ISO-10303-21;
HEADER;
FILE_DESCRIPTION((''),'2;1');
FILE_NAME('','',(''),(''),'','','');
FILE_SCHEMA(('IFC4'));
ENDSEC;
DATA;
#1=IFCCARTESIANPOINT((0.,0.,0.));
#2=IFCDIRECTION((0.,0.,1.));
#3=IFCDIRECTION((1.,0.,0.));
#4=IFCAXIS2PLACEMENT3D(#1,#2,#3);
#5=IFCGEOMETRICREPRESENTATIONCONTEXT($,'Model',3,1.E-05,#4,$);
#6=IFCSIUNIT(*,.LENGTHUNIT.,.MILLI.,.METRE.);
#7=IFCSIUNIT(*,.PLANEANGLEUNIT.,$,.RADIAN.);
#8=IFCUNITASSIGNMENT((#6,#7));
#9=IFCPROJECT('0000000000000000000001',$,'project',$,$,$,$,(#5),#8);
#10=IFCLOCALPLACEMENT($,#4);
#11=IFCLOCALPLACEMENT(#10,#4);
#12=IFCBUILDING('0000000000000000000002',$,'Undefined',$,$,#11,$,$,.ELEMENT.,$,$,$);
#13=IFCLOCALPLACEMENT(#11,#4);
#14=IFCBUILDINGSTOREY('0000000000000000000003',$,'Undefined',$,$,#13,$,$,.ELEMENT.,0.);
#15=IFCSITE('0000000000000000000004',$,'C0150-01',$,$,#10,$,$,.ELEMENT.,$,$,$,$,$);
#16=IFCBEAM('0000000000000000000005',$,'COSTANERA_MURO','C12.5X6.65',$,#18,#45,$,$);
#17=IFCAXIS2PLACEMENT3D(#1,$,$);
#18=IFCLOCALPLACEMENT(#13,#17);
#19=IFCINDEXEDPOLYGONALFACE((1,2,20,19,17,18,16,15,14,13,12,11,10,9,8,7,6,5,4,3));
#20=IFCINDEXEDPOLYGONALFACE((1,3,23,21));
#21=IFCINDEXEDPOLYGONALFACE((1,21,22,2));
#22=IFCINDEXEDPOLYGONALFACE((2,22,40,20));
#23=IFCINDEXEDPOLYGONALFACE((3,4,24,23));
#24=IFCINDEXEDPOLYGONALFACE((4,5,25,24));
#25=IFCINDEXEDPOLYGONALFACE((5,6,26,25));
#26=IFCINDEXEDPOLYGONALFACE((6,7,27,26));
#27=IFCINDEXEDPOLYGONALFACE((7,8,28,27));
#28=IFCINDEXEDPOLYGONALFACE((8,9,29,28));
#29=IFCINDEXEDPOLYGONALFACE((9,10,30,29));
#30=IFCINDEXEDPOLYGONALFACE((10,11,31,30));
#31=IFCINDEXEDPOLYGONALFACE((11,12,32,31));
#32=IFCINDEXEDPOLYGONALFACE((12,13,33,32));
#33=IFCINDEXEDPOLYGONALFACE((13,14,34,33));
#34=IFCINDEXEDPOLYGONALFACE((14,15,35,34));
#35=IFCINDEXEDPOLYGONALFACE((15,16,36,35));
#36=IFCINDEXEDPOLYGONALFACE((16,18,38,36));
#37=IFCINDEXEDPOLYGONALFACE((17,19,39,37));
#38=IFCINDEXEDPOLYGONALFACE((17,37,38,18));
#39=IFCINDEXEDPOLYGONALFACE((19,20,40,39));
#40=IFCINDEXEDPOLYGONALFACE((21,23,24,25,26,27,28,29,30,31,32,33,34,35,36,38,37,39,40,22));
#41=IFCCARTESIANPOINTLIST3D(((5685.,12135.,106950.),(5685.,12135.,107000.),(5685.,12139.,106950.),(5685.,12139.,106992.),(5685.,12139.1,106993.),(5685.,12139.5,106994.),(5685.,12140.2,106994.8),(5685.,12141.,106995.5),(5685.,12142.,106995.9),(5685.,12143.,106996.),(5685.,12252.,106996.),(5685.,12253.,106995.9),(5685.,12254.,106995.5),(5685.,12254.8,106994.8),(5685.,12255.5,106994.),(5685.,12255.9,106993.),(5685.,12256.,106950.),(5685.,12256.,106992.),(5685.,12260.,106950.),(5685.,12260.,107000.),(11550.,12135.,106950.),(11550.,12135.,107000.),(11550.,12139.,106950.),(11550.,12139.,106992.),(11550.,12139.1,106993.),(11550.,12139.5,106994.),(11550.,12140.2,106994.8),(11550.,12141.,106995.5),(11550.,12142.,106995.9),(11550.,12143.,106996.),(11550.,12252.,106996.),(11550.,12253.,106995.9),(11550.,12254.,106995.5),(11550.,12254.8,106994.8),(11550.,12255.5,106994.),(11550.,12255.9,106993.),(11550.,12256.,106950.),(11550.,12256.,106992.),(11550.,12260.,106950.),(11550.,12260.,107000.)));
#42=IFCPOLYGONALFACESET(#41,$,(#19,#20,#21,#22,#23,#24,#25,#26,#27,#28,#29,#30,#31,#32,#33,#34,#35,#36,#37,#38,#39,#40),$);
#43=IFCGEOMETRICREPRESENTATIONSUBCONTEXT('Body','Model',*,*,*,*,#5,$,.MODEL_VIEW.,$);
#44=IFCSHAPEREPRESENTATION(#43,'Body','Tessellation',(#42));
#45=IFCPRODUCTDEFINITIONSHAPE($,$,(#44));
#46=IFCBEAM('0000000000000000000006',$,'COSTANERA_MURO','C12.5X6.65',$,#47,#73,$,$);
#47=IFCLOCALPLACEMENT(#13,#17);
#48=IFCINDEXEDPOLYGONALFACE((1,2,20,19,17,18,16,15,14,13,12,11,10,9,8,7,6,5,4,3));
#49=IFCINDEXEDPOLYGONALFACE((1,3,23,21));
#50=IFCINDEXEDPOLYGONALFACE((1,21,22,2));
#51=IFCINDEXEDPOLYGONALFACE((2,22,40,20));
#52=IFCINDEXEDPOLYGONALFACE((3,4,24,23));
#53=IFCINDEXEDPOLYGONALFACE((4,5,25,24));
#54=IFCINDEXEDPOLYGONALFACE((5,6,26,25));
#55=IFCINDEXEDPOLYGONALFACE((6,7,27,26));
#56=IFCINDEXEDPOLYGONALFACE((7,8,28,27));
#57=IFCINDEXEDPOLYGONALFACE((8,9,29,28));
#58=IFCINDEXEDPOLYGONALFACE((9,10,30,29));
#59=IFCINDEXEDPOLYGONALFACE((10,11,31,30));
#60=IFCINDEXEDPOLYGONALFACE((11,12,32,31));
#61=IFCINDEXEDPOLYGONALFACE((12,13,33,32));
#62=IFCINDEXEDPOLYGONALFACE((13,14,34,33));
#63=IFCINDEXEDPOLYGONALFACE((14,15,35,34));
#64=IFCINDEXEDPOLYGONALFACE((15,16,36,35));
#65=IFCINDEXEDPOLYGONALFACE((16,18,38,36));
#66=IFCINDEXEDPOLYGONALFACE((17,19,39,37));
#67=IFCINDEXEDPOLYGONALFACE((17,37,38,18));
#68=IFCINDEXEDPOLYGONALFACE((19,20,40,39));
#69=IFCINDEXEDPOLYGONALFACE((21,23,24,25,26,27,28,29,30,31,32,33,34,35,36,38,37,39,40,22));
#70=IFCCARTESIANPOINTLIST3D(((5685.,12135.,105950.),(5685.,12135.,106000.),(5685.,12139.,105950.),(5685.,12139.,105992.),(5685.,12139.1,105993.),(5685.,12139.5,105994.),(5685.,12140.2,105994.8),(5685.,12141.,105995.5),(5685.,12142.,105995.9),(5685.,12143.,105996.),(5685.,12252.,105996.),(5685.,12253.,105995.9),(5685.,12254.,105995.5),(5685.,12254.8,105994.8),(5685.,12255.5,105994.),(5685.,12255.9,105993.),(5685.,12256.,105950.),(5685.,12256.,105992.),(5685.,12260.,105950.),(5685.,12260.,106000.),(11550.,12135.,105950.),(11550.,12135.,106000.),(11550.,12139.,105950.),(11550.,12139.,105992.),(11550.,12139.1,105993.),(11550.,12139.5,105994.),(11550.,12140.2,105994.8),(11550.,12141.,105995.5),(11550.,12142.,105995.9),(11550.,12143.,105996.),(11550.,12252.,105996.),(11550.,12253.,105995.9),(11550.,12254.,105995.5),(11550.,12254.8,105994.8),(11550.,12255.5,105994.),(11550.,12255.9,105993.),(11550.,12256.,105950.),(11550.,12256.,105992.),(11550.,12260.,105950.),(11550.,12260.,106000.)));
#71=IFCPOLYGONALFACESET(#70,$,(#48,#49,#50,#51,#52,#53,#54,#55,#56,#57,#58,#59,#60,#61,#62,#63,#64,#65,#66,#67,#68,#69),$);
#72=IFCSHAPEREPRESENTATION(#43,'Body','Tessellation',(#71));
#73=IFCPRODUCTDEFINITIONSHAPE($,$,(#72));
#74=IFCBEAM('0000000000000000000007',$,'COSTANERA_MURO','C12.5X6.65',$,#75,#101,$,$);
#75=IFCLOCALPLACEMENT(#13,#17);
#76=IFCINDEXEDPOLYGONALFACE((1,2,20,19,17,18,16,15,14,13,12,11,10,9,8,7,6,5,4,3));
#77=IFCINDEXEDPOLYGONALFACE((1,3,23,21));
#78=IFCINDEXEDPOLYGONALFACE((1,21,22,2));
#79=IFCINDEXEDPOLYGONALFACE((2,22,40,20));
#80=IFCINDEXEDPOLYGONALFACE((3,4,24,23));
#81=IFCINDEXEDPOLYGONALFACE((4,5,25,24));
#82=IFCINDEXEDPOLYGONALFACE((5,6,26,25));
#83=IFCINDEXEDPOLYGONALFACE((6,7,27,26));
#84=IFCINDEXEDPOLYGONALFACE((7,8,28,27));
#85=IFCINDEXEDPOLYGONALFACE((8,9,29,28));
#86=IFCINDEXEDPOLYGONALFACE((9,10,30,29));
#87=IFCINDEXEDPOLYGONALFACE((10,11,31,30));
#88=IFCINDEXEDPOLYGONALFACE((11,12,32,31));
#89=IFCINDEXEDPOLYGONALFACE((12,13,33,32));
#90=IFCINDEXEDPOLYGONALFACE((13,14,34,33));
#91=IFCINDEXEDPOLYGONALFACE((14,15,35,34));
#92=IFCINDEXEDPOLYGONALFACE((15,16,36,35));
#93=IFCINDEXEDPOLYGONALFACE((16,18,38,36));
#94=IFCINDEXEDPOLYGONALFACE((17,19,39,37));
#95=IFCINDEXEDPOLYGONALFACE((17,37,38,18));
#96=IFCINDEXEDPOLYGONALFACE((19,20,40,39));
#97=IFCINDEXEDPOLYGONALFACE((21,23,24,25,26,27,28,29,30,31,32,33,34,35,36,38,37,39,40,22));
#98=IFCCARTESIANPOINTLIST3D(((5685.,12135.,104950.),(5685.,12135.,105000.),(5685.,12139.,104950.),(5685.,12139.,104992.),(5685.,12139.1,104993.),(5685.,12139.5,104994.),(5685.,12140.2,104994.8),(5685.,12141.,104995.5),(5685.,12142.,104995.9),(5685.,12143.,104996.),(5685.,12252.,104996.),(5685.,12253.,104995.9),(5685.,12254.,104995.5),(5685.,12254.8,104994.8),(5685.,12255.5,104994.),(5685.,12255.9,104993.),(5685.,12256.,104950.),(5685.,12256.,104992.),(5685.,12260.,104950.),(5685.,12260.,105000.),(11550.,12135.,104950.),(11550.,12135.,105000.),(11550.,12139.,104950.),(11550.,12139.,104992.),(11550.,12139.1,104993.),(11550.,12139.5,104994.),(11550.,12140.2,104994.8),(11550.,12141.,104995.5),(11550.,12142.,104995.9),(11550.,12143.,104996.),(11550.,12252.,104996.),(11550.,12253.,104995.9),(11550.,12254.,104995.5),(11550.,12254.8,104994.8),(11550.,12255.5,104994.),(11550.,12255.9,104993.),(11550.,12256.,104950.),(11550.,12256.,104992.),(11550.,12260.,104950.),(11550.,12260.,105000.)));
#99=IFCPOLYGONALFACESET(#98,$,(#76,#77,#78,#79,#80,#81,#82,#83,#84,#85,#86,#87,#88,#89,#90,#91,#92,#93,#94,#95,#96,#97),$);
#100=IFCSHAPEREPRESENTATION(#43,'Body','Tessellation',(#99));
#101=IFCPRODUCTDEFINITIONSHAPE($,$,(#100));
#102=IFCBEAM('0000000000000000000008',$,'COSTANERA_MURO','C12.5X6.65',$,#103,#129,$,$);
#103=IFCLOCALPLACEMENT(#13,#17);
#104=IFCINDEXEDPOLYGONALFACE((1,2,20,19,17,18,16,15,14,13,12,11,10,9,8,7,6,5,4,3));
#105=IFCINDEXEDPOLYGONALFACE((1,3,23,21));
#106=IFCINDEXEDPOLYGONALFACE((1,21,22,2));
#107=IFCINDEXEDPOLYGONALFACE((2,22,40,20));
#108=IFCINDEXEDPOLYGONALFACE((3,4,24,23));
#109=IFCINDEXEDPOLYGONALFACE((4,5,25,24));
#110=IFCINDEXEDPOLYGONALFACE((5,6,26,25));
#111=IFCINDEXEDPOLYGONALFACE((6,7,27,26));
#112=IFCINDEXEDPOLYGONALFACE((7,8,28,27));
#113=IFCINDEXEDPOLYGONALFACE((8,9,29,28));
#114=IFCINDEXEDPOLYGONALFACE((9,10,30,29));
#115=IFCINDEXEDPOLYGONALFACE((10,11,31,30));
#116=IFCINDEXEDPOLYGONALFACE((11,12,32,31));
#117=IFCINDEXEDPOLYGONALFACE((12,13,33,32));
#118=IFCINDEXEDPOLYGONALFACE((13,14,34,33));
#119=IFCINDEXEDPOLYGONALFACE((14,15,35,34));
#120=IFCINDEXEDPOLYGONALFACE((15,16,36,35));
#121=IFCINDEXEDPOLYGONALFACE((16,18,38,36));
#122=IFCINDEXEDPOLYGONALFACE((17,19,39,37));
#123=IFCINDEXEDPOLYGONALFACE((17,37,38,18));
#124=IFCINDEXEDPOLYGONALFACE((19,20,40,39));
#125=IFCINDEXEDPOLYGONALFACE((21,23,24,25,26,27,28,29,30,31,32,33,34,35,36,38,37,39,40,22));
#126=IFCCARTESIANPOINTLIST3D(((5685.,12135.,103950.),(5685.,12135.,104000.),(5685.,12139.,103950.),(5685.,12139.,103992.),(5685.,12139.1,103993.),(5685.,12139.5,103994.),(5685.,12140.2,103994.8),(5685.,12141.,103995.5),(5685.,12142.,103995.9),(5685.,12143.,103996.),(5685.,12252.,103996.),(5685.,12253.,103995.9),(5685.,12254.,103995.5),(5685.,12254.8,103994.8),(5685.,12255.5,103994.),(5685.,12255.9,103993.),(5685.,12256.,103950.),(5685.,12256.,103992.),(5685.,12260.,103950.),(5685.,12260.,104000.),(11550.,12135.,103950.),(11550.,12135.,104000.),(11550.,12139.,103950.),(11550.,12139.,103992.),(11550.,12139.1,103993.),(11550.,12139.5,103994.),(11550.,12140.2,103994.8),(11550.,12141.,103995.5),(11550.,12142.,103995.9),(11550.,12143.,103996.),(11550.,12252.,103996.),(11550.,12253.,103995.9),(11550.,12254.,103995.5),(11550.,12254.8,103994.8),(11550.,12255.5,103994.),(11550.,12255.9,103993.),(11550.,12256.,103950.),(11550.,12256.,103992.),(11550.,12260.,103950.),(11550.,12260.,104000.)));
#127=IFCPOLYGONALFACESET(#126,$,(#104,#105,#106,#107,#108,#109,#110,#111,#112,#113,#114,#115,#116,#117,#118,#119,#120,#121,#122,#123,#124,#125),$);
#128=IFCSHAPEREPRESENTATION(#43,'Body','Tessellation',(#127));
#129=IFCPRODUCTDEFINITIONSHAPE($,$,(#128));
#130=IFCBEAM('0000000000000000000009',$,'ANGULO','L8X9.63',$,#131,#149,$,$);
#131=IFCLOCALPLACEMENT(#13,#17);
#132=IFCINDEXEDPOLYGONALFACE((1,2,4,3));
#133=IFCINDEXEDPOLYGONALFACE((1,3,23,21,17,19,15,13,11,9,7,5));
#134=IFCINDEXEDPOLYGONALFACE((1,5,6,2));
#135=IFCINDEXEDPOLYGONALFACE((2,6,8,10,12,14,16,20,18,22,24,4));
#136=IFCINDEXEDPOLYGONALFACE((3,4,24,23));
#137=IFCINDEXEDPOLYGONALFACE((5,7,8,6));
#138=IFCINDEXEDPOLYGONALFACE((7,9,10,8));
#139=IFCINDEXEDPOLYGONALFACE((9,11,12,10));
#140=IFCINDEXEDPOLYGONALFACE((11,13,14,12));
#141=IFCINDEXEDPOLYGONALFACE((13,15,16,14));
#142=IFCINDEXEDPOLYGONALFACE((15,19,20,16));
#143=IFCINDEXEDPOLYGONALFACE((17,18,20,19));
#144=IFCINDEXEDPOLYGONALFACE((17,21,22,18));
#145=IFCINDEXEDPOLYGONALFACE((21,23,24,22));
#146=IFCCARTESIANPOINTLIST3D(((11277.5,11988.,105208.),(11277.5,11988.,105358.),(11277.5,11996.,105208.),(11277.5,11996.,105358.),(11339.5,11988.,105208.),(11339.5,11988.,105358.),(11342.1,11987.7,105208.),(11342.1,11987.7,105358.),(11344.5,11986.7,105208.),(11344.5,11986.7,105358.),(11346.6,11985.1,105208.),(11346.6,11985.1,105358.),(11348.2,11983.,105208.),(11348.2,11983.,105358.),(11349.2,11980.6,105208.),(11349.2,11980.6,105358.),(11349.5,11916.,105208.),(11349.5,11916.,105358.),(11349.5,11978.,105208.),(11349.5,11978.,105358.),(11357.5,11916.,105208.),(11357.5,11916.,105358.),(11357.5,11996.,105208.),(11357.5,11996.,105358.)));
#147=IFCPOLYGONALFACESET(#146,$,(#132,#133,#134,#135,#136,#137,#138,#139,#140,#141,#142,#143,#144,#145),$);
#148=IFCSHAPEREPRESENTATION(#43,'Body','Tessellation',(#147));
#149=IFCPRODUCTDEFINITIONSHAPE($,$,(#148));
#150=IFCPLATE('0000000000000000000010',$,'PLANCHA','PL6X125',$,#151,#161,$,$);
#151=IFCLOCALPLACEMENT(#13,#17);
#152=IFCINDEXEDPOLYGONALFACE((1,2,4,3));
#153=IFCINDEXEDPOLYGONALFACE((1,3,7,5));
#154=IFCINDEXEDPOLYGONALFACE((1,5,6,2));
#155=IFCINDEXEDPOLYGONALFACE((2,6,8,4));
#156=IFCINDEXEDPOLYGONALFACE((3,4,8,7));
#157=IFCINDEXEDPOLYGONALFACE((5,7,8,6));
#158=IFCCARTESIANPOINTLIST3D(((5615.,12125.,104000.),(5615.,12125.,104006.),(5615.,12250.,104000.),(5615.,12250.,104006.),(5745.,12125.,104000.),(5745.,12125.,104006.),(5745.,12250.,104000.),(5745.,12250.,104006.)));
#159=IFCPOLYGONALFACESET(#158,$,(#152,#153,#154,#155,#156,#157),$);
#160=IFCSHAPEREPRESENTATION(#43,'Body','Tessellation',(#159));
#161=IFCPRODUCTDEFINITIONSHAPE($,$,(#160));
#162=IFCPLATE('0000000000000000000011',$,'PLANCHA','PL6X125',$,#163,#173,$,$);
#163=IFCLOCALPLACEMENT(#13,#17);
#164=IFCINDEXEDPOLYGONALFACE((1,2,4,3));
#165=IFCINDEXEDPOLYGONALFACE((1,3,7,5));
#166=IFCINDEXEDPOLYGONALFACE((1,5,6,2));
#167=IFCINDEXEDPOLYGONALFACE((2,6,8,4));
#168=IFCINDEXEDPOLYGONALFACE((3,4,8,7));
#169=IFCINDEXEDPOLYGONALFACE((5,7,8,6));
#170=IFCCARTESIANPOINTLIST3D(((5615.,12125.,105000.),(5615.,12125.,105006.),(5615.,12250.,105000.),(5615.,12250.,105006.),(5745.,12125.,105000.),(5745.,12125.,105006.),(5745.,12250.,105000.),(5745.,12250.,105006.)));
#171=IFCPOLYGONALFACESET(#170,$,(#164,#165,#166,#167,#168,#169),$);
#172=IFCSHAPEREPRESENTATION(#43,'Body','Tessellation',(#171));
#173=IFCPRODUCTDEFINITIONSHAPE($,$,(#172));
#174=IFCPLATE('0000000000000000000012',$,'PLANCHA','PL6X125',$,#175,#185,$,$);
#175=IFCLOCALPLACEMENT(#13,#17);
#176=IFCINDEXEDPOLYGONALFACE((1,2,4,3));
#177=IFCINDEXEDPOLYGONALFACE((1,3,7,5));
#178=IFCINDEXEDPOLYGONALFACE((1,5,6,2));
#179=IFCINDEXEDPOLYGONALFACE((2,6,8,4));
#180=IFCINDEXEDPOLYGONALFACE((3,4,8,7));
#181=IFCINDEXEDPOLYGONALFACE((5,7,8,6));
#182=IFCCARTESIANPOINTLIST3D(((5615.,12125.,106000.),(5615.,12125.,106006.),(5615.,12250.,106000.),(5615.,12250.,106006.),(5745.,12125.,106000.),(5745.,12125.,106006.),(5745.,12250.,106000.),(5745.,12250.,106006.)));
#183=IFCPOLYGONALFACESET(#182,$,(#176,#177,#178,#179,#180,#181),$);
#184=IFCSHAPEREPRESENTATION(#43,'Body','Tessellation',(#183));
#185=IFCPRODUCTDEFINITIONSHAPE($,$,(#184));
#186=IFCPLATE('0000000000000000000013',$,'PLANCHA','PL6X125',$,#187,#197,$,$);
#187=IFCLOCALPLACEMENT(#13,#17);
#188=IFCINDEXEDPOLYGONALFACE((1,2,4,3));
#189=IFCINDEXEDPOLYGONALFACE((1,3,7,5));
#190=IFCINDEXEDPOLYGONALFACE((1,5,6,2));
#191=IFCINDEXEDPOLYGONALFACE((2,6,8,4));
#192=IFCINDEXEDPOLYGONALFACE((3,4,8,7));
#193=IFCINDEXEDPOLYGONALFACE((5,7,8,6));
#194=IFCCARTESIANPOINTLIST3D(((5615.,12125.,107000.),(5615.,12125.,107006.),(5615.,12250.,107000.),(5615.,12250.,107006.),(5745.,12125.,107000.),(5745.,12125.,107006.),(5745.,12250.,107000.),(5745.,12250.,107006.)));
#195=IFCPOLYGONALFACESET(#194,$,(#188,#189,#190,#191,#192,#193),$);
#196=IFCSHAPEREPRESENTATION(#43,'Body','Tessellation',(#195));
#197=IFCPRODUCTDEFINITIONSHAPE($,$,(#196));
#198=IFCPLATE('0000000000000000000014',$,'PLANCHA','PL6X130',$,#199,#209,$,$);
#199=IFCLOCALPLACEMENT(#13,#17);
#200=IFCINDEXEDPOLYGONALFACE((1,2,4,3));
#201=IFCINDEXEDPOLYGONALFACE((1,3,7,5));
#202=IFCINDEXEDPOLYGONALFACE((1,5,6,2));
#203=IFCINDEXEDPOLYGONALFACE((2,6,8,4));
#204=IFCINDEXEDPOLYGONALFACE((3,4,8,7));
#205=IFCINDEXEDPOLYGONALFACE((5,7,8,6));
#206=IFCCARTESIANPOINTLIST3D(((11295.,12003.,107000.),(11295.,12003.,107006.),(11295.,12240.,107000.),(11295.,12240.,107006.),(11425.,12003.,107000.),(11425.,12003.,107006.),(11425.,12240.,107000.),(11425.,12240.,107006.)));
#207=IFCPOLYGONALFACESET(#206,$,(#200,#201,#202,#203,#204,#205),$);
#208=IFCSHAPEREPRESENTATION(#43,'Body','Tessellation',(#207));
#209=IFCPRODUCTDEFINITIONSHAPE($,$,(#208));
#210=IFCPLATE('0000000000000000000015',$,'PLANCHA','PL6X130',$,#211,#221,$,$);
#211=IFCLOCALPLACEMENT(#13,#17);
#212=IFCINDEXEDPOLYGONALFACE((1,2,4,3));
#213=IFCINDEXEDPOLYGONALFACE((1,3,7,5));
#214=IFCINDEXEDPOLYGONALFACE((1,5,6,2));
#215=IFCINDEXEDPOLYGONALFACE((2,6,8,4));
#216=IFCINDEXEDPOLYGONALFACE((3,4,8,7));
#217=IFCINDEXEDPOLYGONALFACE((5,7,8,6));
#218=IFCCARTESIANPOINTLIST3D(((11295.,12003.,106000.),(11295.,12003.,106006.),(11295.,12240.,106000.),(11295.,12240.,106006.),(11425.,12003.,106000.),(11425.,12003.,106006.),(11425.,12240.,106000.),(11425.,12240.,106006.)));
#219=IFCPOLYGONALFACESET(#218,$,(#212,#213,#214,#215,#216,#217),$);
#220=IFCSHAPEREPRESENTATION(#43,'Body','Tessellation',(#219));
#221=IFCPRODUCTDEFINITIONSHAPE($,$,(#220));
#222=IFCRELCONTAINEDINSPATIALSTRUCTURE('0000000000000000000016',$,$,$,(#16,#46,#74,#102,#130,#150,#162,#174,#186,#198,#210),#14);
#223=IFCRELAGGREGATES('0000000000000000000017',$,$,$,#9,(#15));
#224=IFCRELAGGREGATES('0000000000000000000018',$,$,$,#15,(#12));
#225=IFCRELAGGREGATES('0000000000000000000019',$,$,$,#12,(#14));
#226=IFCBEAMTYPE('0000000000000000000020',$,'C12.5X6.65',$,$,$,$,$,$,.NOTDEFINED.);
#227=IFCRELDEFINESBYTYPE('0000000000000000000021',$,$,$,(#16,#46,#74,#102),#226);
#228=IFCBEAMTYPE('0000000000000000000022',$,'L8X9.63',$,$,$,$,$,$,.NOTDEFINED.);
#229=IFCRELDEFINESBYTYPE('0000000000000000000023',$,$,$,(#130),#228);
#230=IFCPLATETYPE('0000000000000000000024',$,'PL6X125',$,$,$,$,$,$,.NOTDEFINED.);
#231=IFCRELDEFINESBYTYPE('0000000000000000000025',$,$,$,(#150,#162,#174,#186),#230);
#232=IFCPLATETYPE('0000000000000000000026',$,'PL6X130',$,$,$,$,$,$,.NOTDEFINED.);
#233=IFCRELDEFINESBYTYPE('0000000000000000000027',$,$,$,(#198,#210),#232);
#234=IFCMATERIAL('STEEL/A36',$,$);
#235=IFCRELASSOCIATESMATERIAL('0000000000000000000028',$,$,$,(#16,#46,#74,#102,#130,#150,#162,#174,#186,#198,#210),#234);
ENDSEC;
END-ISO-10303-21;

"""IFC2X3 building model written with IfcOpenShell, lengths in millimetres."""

from ifc_helpers import new_model, si_unit, frame, origin_with_axes, origin_2d_with_axis, place, context, subcontext, project, spatial, polyline, l_section, u_section, outline, extrude, material, type_object, element, save


model = new_model("IFC2X3")

# Units and contexts
model_context = context("Model", 3, precision=1e-05, world=origin_with_axes())
body_context = subcontext(model_context, "Body", "Model", "MODEL_VIEW")
ifc_project = project(units=[si_unit("LENGTHUNIT", "METRE", prefix="MILLI"), si_unit("PLANEANGLEUNIT", "RADIAN")], contexts=[model_context])

# Site, building, storey
site_placement = place(None, origin_with_axes())
site = spatial("IfcSite", under=ifc_project, at=site_placement, Name="C0150-01", CompositionType="ELEMENT")
building_placement = place(site_placement, origin_with_axes())
building = spatial("IfcBuilding", under=site, at=building_placement, Name="Undefined", CompositionType="ELEMENT")
storey_placement = place(building_placement, origin_with_axes())
storey = spatial("IfcBuildingStorey", under=building, at=storey_placement, Name="Undefined", CompositionType="ELEMENT", Elevation=0.0)

# Beams
ifc_material_1 = material(Name="STEEL/A36")
beam_type_1 = type_object("IfcBeamType", Name="C12.5X6.65", PredefinedType="NOTDEFINED")
for number, where, z_axis, x_axis, name in (
    (1, (5685.0, 12197.5, 106975.0), (0.0, -1.0, 0.0), (1.0, 0.0, 0.0), "COSTANERA_MURO"),
    (2, (5685.0, 12197.5, 105975.0), (0.0, -1.0, 0.0), (1.0, 0.0, 0.0), "COSTANERA_MURO"),
    (3, (5685.0, 12197.5, 104975.0), (0.0, -1.0, 0.0), (1.0, 0.0, 0.0), "COSTANERA_MURO"),
    (4, (5685.0, 12197.5, 103975.0), (0.0, -1.0, 0.0), (1.0, 0.0, 0.0), "COSTANERA_MURO"),
):
    element("IfcBeam", number, at=place(storey_placement, frame(where, z_axis=z_axis, x_axis=x_axis)), inside=storey, type_object=beam_type_1, material=ifc_material_1, Name=name, Description="C12.5X6.65", context=body_context, shape_type="SweptSolid", body=[
        extrude(u_section(Depth=125.0, FlangeWidth=50.0, WebThickness=4.0, FlangeThickness=4.0, FilletRadius=4.0, at=origin_2d_with_axis()), frame((5865.0, 0.0, 0.0), z_axis=(-1.0, 0.0, 0.0), x_axis=(0.0, -1.0, 0.0)), (0.0, 0.0, 1.0), 5865.0),
    ])
beam_type_2 = type_object("IfcBeamType", Name="L8X9.63", PredefinedType="NOTDEFINED")
beam_placement = place(storey_placement, frame((11317.5, 11956.0, 105358.0), z_axis=(0.0, -1.0, 0.0), x_axis=(0.0, 0.0, -1.0)))
element("IfcBeam", 5, at=beam_placement, inside=storey, type_object=beam_type_2, material=ifc_material_1, Name="ANGULO", Description="L8X9.63", context=body_context, shape_type="SweptSolid", body=[
    extrude(l_section(Depth=80.0, Width=80.0, Thickness=8.0, FilletRadius=10.0, at=origin_2d_with_axis()), frame((150.0, 0.0, 0.0), z_axis=(-1.0, 0.0, 0.0), x_axis=(0.0, -1.0, 0.0)), (0.0, 0.0, 1.0), 150.0),
])

# Plates
plate_type_1 = type_object("IfcPlateType", Name="PL6X125", PredefinedType="NOTDEFINED")
for number, where, z_axis, x_axis, name in (
    (6, (5745.0, 12125.0, 104003.0), (0.0, 0.000004, -1.0), (-1.0, 0.0, 0.0), "PLANCHA"),
    (7, (5745.0, 12125.0, 105003.0), (0.0, 0.000004, -1.0), (-1.0, 0.0, 0.0), "PLANCHA"),
    (8, (5745.0, 12125.0, 106003.0), (0.0, 0.000004, -1.0), (-1.0, 0.0, 0.0), "PLANCHA"),
    (9, (5745.0, 12125.0, 107003.0), (0.0, 0.000004, -1.0), (-1.0, 0.0, 0.0), "PLANCHA"),
):
    element("IfcPlate", number, at=place(storey_placement, frame(where, z_axis=z_axis, x_axis=x_axis)), inside=storey, type_object=plate_type_1, material=ifc_material_1, Name=name, Description="PL6X125", context=body_context, shape_type="SweptSolid", body=[
        extrude(outline(polyline([(0.0, 0.0), (130.0, 0.0), (130.0, 125.0), (0.0, 125.0), (0.0, 0.0)])), frame((0.0, 0.0, -3.0), z_axis=(0.0, 0.0, 1.0), x_axis=(1.0, 0.0, 0.0)), (0.0, 0.0, 1.0), 6.0),
    ])
plate_type_2 = type_object("IfcPlateType", Name="PL6X130", PredefinedType="NOTDEFINED")
for number, where, z_axis, x_axis, name in (
    (10, (11295.0, 12003.0, 107003.0), (0.0, -0.000002, 1.0), (1.0, 0.0, 0.0), "PLANCHA"),
    (11, (11295.0, 12003.0, 106003.0), (0.0, -0.000002, 1.0), (1.0, 0.0, 0.0), "PLANCHA"),
):
    element("IfcPlate", number, at=place(storey_placement, frame(where, z_axis=z_axis, x_axis=x_axis)), inside=storey, type_object=plate_type_2, material=ifc_material_1, Name=name, Description="PL6X130", context=body_context, shape_type="SweptSolid", body=[
        extrude(outline(polyline([(0.0, 0.0), (130.0, 0.0), (130.0, 237.0), (0.0, 237.0), (0.0, 0.0)])), frame((0.0, 0.0, -3.0), z_axis=(0.0, 0.0, 1.0), x_axis=(1.0, 0.0, 0.0)), (0.0, 0.0, 1.0), 6.0),
    ])

save(model, "model.ifc")
